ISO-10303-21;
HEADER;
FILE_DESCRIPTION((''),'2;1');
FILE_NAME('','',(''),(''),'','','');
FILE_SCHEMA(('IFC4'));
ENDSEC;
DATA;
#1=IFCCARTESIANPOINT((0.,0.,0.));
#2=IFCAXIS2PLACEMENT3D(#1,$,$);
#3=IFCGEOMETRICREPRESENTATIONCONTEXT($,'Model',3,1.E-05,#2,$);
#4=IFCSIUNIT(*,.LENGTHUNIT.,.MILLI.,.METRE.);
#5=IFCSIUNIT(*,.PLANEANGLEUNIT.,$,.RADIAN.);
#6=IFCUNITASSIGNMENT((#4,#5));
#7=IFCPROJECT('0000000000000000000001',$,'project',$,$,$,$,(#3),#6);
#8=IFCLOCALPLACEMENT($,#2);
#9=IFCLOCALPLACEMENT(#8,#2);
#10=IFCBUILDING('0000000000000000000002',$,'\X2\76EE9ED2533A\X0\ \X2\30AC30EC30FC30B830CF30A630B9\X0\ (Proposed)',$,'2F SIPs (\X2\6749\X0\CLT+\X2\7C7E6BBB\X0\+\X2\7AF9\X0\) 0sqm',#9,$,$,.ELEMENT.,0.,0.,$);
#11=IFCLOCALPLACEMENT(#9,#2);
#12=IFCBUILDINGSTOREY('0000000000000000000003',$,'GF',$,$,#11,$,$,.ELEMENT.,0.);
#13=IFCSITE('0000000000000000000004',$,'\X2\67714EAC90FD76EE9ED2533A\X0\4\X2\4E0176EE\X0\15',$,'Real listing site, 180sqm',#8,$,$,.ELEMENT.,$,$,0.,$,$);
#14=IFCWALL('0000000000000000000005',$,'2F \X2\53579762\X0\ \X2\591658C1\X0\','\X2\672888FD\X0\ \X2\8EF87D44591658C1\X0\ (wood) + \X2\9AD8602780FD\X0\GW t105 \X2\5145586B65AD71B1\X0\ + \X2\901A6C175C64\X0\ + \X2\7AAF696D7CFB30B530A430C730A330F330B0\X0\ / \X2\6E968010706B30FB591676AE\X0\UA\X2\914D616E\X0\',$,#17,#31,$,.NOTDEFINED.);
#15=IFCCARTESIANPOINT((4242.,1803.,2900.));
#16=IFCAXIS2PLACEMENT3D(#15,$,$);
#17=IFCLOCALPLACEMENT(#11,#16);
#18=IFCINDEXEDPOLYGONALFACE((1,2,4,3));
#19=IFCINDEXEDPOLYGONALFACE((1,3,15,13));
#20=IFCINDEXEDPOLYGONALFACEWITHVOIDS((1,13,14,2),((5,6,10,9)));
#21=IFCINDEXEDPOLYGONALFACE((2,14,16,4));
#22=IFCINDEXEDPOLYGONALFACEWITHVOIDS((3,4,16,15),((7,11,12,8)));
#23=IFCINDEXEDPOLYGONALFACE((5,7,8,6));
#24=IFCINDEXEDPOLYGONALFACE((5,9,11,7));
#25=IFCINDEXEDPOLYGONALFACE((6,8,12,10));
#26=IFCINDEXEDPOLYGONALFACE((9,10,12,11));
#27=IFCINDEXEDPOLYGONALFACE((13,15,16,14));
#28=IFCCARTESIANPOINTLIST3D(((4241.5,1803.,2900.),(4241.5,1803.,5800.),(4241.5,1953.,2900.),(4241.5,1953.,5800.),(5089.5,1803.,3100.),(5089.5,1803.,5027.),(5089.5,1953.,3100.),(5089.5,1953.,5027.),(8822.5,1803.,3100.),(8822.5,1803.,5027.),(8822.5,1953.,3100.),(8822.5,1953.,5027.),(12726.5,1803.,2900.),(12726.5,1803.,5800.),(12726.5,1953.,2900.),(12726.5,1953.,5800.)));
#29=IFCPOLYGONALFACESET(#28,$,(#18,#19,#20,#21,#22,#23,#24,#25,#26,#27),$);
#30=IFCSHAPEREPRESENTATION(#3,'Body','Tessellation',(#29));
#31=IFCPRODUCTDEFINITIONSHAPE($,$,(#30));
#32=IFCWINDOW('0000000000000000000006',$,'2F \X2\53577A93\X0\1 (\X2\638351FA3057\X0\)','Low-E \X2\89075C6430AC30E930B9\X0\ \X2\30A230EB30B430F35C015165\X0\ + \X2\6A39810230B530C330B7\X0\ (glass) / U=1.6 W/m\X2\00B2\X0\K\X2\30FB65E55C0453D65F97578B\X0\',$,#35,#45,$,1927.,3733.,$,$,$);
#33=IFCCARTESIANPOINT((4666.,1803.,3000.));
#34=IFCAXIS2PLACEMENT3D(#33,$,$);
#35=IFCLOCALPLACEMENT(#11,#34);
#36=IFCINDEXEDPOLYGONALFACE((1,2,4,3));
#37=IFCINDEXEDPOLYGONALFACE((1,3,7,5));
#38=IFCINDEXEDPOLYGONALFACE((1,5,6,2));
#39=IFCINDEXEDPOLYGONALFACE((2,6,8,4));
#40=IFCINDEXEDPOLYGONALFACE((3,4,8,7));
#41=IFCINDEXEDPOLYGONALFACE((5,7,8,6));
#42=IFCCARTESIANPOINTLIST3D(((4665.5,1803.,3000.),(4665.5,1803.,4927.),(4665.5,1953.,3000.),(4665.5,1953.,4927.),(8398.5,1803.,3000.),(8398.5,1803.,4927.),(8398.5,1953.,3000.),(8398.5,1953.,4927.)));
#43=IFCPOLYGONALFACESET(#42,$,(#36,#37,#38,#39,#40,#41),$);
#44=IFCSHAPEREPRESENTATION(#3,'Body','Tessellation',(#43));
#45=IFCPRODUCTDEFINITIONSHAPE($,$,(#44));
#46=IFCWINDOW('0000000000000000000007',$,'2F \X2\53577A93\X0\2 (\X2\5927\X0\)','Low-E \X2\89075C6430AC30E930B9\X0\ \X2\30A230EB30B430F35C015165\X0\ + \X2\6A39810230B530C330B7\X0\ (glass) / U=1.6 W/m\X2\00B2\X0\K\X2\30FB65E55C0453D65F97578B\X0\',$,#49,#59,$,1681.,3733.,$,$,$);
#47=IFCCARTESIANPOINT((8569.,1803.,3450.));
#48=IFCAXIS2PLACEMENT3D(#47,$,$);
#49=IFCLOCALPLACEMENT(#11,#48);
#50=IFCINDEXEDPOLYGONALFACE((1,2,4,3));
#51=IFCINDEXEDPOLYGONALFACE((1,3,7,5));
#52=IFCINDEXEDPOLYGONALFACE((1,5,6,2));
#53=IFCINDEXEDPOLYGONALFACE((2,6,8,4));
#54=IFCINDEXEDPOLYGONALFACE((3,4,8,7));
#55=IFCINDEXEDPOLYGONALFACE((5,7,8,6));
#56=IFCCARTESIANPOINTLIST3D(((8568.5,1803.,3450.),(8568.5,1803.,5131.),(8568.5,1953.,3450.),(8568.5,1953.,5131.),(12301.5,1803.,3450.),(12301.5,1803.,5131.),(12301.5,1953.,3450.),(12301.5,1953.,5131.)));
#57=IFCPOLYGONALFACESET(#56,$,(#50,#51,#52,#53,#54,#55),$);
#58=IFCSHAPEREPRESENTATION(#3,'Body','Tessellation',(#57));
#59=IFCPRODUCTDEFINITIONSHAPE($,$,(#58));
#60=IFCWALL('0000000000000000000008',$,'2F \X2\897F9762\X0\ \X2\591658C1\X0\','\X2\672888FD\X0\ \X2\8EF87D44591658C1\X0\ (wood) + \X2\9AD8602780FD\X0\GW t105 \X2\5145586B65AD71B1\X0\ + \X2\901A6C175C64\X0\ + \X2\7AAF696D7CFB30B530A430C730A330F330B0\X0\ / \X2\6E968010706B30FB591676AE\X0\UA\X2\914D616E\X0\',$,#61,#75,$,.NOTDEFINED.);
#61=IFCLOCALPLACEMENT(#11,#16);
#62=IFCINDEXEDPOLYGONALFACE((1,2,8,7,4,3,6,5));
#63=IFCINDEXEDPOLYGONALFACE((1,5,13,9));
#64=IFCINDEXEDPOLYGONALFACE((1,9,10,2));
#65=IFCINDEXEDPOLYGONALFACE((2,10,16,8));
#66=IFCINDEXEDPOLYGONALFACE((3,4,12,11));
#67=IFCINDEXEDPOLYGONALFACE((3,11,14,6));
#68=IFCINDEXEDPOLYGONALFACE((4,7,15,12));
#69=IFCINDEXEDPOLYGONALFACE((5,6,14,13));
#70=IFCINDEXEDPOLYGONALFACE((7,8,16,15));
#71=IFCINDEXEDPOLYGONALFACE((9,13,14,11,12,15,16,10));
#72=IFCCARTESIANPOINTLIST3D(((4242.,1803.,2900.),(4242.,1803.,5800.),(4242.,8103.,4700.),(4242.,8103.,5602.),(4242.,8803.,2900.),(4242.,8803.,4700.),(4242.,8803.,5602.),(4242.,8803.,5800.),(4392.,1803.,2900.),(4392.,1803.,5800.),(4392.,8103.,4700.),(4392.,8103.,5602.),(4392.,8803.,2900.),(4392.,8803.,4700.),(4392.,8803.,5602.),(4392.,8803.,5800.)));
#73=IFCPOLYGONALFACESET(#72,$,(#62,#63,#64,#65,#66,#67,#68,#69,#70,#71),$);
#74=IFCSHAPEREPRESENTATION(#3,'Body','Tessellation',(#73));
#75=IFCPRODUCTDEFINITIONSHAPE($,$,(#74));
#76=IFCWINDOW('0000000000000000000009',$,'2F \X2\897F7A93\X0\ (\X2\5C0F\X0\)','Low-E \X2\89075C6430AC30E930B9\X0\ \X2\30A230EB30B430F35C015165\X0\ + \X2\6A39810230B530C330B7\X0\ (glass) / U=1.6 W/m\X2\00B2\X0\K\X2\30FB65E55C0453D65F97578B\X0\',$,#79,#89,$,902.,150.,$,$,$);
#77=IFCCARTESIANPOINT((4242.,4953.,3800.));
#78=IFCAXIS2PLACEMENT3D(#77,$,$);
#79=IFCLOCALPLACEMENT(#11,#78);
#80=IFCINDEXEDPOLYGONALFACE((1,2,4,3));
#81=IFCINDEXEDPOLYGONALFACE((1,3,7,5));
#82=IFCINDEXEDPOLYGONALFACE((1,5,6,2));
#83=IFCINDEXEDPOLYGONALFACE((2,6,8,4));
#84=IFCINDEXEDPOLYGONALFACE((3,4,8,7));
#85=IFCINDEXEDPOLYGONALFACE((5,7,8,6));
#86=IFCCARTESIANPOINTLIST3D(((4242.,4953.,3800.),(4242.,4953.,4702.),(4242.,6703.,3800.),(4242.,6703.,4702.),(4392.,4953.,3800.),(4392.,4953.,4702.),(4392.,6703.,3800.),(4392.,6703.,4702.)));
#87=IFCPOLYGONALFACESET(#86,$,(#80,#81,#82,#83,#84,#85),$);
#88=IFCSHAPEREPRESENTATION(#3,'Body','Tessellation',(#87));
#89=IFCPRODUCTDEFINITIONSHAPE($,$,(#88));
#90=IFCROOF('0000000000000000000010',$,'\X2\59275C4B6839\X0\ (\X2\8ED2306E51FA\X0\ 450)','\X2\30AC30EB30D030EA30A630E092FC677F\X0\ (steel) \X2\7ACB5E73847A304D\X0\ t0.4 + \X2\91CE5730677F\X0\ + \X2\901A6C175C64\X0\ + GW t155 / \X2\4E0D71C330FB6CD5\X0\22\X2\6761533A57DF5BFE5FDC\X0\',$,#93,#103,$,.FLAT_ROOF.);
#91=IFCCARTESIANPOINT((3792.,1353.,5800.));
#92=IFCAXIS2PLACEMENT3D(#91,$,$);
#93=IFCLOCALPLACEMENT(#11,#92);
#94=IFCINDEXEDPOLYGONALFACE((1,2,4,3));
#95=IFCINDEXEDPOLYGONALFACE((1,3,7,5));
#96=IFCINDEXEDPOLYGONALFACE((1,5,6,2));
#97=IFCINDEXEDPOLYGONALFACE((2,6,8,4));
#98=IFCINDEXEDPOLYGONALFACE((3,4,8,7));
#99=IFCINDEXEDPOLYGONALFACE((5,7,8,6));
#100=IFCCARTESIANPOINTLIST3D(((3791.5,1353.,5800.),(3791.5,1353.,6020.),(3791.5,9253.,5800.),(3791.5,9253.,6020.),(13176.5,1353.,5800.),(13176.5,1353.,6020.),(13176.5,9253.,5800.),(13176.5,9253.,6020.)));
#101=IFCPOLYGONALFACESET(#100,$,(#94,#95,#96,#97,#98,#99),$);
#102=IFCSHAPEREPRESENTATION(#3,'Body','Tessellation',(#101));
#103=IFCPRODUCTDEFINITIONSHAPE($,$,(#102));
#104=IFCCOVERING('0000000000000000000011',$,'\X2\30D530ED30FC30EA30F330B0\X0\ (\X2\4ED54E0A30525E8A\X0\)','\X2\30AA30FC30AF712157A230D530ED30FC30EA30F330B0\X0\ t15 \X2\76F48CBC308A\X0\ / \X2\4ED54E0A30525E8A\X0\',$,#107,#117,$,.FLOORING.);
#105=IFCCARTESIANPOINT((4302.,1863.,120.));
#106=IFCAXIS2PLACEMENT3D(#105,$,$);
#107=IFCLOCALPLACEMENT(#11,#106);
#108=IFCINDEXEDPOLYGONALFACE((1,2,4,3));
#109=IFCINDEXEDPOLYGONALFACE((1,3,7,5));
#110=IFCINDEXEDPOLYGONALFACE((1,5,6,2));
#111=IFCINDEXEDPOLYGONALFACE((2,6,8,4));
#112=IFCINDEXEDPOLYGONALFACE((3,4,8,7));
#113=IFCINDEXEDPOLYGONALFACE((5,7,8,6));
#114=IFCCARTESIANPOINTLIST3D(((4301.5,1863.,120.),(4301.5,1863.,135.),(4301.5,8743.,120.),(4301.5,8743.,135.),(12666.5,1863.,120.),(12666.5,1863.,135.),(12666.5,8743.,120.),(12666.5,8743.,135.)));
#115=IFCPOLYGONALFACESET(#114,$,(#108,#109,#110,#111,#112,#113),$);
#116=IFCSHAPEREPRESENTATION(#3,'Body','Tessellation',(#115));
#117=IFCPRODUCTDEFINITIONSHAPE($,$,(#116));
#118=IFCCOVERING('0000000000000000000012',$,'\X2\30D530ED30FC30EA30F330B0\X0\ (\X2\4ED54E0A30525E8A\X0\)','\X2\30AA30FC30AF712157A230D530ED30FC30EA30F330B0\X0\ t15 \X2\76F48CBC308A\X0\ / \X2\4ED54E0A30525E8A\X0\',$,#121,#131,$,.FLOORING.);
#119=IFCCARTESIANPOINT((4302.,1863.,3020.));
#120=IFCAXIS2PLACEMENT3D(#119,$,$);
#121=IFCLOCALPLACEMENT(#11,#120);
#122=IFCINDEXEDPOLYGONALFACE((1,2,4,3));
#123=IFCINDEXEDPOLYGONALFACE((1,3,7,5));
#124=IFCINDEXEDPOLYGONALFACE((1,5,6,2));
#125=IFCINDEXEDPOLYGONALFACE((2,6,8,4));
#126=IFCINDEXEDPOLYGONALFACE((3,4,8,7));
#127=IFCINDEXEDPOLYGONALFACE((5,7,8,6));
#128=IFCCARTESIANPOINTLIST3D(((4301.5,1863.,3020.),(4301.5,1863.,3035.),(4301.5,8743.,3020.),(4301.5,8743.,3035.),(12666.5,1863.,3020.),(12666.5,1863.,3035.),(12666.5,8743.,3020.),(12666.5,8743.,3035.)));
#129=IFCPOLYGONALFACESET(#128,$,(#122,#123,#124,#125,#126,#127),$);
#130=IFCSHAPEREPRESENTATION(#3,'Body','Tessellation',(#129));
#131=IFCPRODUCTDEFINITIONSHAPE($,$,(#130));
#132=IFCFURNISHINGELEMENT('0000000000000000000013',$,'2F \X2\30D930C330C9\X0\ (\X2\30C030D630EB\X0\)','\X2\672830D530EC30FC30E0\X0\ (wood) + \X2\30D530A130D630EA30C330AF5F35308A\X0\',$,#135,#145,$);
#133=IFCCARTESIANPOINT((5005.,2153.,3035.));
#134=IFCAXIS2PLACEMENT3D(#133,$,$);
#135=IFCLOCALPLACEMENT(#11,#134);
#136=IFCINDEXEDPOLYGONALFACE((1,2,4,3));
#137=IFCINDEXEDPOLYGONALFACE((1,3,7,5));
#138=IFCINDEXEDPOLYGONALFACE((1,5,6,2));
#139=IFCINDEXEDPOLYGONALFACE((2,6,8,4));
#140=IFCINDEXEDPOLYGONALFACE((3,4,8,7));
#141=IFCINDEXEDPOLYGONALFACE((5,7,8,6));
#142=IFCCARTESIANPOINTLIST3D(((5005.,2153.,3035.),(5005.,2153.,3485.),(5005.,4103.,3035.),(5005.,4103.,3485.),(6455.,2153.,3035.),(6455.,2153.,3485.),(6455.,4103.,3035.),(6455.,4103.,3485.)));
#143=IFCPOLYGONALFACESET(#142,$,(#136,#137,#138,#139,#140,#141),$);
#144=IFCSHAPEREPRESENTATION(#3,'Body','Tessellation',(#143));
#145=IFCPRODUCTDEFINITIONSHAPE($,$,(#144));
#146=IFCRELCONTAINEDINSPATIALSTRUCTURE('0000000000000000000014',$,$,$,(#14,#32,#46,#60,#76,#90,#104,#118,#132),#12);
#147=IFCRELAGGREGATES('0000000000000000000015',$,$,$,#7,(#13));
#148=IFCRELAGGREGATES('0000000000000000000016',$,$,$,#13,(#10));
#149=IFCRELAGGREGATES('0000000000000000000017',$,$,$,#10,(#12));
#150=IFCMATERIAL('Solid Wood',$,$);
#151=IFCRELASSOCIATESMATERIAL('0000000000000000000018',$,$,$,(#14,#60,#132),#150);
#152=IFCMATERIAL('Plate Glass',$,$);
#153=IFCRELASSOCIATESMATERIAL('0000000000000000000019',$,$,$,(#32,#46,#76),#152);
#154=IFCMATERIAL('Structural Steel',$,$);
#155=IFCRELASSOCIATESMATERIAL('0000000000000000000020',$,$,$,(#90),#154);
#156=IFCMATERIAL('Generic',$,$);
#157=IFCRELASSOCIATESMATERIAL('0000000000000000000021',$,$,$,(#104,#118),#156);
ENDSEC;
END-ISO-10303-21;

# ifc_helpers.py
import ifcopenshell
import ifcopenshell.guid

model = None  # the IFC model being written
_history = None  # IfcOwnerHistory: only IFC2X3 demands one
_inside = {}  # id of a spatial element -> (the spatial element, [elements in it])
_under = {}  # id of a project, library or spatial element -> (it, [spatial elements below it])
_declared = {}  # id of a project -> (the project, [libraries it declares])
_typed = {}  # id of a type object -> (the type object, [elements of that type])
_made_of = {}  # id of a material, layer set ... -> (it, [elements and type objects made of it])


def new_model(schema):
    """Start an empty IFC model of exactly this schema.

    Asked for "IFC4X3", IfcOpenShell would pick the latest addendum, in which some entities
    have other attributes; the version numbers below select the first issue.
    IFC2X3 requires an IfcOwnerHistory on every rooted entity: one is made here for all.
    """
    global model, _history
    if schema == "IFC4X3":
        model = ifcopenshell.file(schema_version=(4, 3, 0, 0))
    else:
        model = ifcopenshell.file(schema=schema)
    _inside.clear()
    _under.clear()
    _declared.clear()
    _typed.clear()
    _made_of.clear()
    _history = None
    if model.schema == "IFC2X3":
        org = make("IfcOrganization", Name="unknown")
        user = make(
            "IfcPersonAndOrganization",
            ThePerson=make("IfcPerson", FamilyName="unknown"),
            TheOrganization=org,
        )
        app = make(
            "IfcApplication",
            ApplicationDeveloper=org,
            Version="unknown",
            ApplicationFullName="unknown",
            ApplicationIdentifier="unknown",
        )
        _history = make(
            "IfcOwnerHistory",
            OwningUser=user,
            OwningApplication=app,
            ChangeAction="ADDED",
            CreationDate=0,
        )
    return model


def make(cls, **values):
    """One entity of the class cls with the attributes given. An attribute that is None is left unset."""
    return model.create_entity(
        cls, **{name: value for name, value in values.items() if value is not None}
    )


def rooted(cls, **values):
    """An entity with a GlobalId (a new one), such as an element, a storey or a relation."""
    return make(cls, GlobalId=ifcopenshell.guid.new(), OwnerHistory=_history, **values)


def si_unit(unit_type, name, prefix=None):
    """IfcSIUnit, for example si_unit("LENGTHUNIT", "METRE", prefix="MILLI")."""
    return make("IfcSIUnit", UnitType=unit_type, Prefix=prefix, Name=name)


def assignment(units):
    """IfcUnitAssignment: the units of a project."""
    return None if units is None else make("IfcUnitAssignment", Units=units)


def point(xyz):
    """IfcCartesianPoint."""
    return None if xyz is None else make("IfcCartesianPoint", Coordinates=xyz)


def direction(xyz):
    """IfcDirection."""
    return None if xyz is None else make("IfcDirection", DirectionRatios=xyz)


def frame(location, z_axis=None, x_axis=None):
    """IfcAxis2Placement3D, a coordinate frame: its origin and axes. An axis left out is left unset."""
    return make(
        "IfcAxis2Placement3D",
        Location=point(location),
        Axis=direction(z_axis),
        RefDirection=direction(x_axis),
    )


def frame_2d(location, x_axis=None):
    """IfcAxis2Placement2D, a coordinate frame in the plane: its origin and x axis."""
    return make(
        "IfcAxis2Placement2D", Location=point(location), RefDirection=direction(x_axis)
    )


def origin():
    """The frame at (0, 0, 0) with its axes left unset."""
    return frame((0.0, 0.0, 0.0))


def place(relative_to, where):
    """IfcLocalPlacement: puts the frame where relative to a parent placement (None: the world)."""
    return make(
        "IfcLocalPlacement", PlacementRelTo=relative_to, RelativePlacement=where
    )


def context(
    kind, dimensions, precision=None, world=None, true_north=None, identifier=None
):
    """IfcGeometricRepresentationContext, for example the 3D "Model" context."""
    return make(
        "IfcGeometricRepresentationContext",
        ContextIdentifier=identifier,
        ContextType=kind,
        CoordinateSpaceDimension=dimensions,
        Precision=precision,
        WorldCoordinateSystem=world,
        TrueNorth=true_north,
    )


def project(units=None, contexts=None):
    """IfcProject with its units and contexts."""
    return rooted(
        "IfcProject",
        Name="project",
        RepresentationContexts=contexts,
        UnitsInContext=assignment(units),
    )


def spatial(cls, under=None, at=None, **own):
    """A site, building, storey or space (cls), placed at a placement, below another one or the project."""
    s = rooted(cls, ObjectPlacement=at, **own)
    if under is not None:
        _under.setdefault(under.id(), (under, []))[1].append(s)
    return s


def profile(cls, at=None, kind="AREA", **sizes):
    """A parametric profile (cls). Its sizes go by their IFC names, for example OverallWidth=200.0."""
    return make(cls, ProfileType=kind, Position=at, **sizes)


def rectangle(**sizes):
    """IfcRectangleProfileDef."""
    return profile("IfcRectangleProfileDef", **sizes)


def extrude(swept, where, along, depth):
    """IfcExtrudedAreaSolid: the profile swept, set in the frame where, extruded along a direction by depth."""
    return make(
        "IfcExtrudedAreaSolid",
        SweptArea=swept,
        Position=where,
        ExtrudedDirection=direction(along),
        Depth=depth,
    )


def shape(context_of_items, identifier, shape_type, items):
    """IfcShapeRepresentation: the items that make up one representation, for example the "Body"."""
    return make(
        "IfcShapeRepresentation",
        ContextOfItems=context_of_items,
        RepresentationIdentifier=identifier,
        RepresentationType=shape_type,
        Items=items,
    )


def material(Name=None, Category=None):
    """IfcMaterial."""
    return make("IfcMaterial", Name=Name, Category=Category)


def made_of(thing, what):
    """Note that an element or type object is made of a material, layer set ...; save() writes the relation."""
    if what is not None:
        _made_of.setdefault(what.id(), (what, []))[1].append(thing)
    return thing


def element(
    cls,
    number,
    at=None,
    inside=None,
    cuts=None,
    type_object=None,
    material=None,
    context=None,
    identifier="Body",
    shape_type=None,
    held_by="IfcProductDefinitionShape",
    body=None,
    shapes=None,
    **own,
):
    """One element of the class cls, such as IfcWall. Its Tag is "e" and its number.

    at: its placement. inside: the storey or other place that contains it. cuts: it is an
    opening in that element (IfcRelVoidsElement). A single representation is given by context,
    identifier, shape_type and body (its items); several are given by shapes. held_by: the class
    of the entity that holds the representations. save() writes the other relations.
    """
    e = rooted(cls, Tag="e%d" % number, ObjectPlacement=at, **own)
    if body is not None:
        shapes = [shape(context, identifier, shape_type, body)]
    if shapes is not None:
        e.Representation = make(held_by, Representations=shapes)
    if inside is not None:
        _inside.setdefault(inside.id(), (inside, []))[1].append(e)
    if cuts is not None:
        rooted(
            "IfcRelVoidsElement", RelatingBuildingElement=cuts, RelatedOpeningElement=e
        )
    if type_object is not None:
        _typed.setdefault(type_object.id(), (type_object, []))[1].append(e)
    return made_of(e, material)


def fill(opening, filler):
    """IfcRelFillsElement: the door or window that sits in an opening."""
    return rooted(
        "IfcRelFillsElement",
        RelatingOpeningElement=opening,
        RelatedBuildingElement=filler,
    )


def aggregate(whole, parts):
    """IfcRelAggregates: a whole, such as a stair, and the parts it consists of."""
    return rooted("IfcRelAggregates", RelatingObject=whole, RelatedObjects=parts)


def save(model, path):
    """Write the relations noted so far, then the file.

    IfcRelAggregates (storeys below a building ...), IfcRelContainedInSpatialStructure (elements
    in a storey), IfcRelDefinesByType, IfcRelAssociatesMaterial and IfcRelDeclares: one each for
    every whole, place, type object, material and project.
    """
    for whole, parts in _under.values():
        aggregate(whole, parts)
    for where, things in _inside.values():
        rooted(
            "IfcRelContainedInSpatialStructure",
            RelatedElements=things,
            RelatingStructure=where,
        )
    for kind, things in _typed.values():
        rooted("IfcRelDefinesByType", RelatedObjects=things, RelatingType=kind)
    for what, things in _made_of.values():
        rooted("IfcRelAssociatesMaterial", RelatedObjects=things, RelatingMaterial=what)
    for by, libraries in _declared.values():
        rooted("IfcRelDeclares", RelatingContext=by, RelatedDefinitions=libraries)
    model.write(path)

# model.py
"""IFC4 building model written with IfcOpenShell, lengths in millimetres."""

from ifc_helpers import new_model, si_unit, frame, frame_2d, origin, place, context, project, spatial, rectangle, extrude, material, element, fill, save


model = new_model("IFC4")

# Units and contexts
model_context = context("Model", 3, precision=1e-05, world=origin())
ifc_project = project(units=[si_unit("LENGTHUNIT", "METRE", prefix="MILLI"), si_unit("PLANEANGLEUNIT", "RADIAN")], contexts=[model_context])

# Site, building, storey
site_placement = place(None, origin())
site = spatial("IfcSite", under=ifc_project, at=site_placement, Name="東京都目黒区4丁目15", ObjectType="Real listing site, 180sqm", CompositionType="ELEMENT", RefElevation=0.0)
building_placement = place(site_placement, origin())
building = spatial("IfcBuilding", under=site, at=building_placement, Name="目黒区 ガレージハウス (Proposed)", ObjectType="2F SIPs (杉CLT+籾殻+竹) 0sqm", CompositionType="ELEMENT", ElevationOfRefHeight=0.0, ElevationOfTerrain=0.0)
storey_placement = place(building_placement, origin())
storey = spatial("IfcBuildingStorey", under=building, at=storey_placement, Name="GF", CompositionType="ELEMENT", Elevation=0.0)

# Shared definitions
ifc_material_1 = material(Name="Solid Wood")

# Shared definitions
ifc_material_2 = material(Name="Plate Glass")

# Wall, openings, windows
wall_1_placement = place(storey_placement, frame((4242.0, 1803.0, 2900.0)))
wall_1 = element("IfcWall", 1, at=wall_1_placement, inside=storey, material=ifc_material_1, Name="2F 南面 外壁", Description="木製 軸組外壁 (wood) + 高性能GW t105 充填断熱 + 通気層 + 窯業系サイディング / 準耐火・外皮UA配慮", PredefinedType="NOTDEFINED", context=model_context, shape_type="SweptSolid", body=[
    extrude(rectangle(XDim=8485.0, YDim=150.0, at=frame_2d((4242.0, 75.0))), frame((4242.0, 1803.0, 2900.0)), (0.0, 0.0, 1.0), 2900.0),
])
opening_1_placement = place(storey_placement, frame((4666.0, 1803.0, 3000.0)))
opening_1 = element("IfcOpeningElement", 2, at=opening_1_placement, cuts=wall_1, PredefinedType="NOTDEFINED", context=model_context, shape_type="SweptSolid", body=[
    extrude(rectangle(XDim=3733.0, YDim=150.0, at=frame_2d((1866.0, 75.0))), frame((4666.0, 1803.0, 3000.0)), (0.0, 0.0, 1.0), 1927.0),
])
opening_2_placement = place(storey_placement, frame((8569.0, 1803.0, 3450.0)))
opening_2 = element("IfcOpeningElement", 3, at=opening_2_placement, cuts=wall_1, PredefinedType="NOTDEFINED", context=model_context, shape_type="SweptSolid", body=[
    extrude(rectangle(XDim=3733.0, YDim=150.0, at=frame_2d((1866.0, 75.0))), frame((8569.0, 1803.0, 3450.0)), (0.0, 0.0, 1.0), 1681.0),
])
window_1_placement = place(storey_placement, frame((4666.0, 1803.0, 3000.0)))
window_1 = element("IfcWindow", 4, at=window_1_placement, inside=storey, material=ifc_material_2, Name="2F 南窓1 (掃出し)", Description="Low-E 複層ガラス アルゴン封入 + 樹脂サッシ (glass) / U=1.6 W/m²K・日射取得型", OverallHeight=1927.0, OverallWidth=3733.0, context=model_context, shape_type="SweptSolid", body=[
    extrude(rectangle(XDim=3733.0, YDim=150.0, at=frame_2d((1866.0, 75.0))), frame((4666.0, 1803.0, 3000.0)), (0.0, 0.0, 1.0), 1927.0),
])
fill(opening_1, window_1)
window_2_placement = place(storey_placement, frame((8569.0, 1803.0, 3450.0)))
window_2 = element("IfcWindow", 5, at=window_2_placement, inside=storey, material=ifc_material_2, Name="2F 南窓2 (大)", Description="Low-E 複層ガラス アルゴン封入 + 樹脂サッシ (glass) / U=1.6 W/m²K・日射取得型", OverallHeight=1681.0, OverallWidth=3733.0, context=model_context, shape_type="SweptSolid", body=[
    extrude(rectangle(XDim=3733.0, YDim=150.0, at=frame_2d((1866.0, 75.0))), frame((8569.0, 1803.0, 3450.0)), (0.0, 0.0, 1.0), 1681.0),
])
fill(opening_2, window_2)

# Wall, opening, window
wall_2_placement = place(storey_placement, frame((4242.0, 1803.0, 2900.0)))
wall_2 = element("IfcWall", 6, at=wall_2_placement, inside=storey, material=ifc_material_1, Name="2F 西面 外壁", Description="木製 軸組外壁 (wood) + 高性能GW t105 充填断熱 + 通気層 + 窯業系サイディング / 準耐火・外皮UA配慮", PredefinedType="NOTDEFINED", context=model_context, shape_type="SweptSolid", body=[
    extrude(rectangle(XDim=150.0, YDim=7000.0, at=frame_2d((75.0, 3500.0))), frame((4242.0, 1803.0, 2900.0)), (0.0, 0.0, 1.0), 2900.0),
])
opening_3_placement = place(storey_placement, frame((4242.0, 4953.0, 3800.0)))
opening_3 = element("IfcOpeningElement", 7, at=opening_3_placement, cuts=wall_2, PredefinedType="NOTDEFINED", context=model_context, shape_type="SweptSolid", body=[
    extrude(rectangle(XDim=150.0, YDim=1750.0, at=frame_2d((75.0, 875.0))), frame((4242.0, 4953.0, 3800.0)), (0.0, 0.0, 1.0), 902.0),
])
window_3_placement = place(storey_placement, frame((4242.0, 4953.0, 3800.0)))
window_3 = element("IfcWindow", 8, at=window_3_placement, inside=storey, material=ifc_material_2, Name="2F 西窓 (小)", Description="Low-E 複層ガラス アルゴン封入 + 樹脂サッシ (glass) / U=1.6 W/m²K・日射取得型", OverallHeight=902.0, OverallWidth=150.0, context=model_context, shape_type="SweptSolid", body=[
    extrude(rectangle(XDim=150.0, YDim=1750.0, at=frame_2d((75.0, 875.0))), frame((4242.0, 4953.0, 3800.0)), (0.0, 0.0, 1.0), 902.0),
])
fill(opening_3, window_3)

# Roof
ifc_material_3 = material(Name="Structural Steel")
roof_placement = place(storey_placement, frame((3792.0, 1353.0, 5800.0)))
element("IfcRoof", 9, at=roof_placement, inside=storey, material=ifc_material_3, Name="大屋根 (軒の出 450)", Description="ガルバリウム鋼板 (steel) 立平葺き t0.4 + 野地板 + 通気層 + GW t155 / 不燃・法22条区域対応", PredefinedType="FLAT_ROOF", context=model_context, shape_type="SweptSolid", body=[
    extrude(rectangle(XDim=9385.0, YDim=7900.0, at=frame_2d((4692.0, 3950.0))), frame((3792.0, 1353.0, 5800.0)), (0.0, 0.0, 1.0), 220.0),
])

# Coverings
ifc_material_4 = material(Name="Generic")
covering_1_placement = place(storey_placement, frame((4302.0, 1863.0, 120.0)))
element("IfcCovering", 10, at=covering_1_placement, inside=storey, material=ifc_material_4, Name="フローリング (仕上げ床)", Description="オーク無垢フローリング t15 直貼り / 仕上げ床", PredefinedType="FLOORING", context=model_context, shape_type="SweptSolid", body=[
    extrude(rectangle(XDim=8365.0, YDim=6880.0, at=frame_2d((4182.0, 3440.0))), frame((4302.0, 1863.0, 120.0)), (0.0, 0.0, 1.0), 15.0),
])
covering_2_placement = place(storey_placement, frame((4302.0, 1863.0, 3020.0)))
element("IfcCovering", 11, at=covering_2_placement, inside=storey, material=ifc_material_4, Name="フローリング (仕上げ床)", Description="オーク無垢フローリング t15 直貼り / 仕上げ床", PredefinedType="FLOORING", context=model_context, shape_type="SweptSolid", body=[
    extrude(rectangle(XDim=8365.0, YDim=6880.0, at=frame_2d((4182.0, 3440.0))), frame((4302.0, 1863.0, 3020.0)), (0.0, 0.0, 1.0), 15.0),
])

# Furnishing element
furnishing_placement = place(storey_placement, frame((5005.0, 2153.0, 3035.0)))
element("IfcFurnishingElement", 12, at=furnishing_placement, inside=storey, material=ifc_material_1, Name="2F ベッド (ダブル)", Description="木フレーム (wood) + ファブリック張り", context=model_context, shape_type="SweptSolid", body=[
    extrude(rectangle(XDim=1450.0, YDim=1950.0, at=frame_2d((725.0, 975.0))), frame((5005.0, 2153.0, 3035.0)), (0.0, 0.0, 1.0), 450.0),
])

save(model, "model.ifc")
